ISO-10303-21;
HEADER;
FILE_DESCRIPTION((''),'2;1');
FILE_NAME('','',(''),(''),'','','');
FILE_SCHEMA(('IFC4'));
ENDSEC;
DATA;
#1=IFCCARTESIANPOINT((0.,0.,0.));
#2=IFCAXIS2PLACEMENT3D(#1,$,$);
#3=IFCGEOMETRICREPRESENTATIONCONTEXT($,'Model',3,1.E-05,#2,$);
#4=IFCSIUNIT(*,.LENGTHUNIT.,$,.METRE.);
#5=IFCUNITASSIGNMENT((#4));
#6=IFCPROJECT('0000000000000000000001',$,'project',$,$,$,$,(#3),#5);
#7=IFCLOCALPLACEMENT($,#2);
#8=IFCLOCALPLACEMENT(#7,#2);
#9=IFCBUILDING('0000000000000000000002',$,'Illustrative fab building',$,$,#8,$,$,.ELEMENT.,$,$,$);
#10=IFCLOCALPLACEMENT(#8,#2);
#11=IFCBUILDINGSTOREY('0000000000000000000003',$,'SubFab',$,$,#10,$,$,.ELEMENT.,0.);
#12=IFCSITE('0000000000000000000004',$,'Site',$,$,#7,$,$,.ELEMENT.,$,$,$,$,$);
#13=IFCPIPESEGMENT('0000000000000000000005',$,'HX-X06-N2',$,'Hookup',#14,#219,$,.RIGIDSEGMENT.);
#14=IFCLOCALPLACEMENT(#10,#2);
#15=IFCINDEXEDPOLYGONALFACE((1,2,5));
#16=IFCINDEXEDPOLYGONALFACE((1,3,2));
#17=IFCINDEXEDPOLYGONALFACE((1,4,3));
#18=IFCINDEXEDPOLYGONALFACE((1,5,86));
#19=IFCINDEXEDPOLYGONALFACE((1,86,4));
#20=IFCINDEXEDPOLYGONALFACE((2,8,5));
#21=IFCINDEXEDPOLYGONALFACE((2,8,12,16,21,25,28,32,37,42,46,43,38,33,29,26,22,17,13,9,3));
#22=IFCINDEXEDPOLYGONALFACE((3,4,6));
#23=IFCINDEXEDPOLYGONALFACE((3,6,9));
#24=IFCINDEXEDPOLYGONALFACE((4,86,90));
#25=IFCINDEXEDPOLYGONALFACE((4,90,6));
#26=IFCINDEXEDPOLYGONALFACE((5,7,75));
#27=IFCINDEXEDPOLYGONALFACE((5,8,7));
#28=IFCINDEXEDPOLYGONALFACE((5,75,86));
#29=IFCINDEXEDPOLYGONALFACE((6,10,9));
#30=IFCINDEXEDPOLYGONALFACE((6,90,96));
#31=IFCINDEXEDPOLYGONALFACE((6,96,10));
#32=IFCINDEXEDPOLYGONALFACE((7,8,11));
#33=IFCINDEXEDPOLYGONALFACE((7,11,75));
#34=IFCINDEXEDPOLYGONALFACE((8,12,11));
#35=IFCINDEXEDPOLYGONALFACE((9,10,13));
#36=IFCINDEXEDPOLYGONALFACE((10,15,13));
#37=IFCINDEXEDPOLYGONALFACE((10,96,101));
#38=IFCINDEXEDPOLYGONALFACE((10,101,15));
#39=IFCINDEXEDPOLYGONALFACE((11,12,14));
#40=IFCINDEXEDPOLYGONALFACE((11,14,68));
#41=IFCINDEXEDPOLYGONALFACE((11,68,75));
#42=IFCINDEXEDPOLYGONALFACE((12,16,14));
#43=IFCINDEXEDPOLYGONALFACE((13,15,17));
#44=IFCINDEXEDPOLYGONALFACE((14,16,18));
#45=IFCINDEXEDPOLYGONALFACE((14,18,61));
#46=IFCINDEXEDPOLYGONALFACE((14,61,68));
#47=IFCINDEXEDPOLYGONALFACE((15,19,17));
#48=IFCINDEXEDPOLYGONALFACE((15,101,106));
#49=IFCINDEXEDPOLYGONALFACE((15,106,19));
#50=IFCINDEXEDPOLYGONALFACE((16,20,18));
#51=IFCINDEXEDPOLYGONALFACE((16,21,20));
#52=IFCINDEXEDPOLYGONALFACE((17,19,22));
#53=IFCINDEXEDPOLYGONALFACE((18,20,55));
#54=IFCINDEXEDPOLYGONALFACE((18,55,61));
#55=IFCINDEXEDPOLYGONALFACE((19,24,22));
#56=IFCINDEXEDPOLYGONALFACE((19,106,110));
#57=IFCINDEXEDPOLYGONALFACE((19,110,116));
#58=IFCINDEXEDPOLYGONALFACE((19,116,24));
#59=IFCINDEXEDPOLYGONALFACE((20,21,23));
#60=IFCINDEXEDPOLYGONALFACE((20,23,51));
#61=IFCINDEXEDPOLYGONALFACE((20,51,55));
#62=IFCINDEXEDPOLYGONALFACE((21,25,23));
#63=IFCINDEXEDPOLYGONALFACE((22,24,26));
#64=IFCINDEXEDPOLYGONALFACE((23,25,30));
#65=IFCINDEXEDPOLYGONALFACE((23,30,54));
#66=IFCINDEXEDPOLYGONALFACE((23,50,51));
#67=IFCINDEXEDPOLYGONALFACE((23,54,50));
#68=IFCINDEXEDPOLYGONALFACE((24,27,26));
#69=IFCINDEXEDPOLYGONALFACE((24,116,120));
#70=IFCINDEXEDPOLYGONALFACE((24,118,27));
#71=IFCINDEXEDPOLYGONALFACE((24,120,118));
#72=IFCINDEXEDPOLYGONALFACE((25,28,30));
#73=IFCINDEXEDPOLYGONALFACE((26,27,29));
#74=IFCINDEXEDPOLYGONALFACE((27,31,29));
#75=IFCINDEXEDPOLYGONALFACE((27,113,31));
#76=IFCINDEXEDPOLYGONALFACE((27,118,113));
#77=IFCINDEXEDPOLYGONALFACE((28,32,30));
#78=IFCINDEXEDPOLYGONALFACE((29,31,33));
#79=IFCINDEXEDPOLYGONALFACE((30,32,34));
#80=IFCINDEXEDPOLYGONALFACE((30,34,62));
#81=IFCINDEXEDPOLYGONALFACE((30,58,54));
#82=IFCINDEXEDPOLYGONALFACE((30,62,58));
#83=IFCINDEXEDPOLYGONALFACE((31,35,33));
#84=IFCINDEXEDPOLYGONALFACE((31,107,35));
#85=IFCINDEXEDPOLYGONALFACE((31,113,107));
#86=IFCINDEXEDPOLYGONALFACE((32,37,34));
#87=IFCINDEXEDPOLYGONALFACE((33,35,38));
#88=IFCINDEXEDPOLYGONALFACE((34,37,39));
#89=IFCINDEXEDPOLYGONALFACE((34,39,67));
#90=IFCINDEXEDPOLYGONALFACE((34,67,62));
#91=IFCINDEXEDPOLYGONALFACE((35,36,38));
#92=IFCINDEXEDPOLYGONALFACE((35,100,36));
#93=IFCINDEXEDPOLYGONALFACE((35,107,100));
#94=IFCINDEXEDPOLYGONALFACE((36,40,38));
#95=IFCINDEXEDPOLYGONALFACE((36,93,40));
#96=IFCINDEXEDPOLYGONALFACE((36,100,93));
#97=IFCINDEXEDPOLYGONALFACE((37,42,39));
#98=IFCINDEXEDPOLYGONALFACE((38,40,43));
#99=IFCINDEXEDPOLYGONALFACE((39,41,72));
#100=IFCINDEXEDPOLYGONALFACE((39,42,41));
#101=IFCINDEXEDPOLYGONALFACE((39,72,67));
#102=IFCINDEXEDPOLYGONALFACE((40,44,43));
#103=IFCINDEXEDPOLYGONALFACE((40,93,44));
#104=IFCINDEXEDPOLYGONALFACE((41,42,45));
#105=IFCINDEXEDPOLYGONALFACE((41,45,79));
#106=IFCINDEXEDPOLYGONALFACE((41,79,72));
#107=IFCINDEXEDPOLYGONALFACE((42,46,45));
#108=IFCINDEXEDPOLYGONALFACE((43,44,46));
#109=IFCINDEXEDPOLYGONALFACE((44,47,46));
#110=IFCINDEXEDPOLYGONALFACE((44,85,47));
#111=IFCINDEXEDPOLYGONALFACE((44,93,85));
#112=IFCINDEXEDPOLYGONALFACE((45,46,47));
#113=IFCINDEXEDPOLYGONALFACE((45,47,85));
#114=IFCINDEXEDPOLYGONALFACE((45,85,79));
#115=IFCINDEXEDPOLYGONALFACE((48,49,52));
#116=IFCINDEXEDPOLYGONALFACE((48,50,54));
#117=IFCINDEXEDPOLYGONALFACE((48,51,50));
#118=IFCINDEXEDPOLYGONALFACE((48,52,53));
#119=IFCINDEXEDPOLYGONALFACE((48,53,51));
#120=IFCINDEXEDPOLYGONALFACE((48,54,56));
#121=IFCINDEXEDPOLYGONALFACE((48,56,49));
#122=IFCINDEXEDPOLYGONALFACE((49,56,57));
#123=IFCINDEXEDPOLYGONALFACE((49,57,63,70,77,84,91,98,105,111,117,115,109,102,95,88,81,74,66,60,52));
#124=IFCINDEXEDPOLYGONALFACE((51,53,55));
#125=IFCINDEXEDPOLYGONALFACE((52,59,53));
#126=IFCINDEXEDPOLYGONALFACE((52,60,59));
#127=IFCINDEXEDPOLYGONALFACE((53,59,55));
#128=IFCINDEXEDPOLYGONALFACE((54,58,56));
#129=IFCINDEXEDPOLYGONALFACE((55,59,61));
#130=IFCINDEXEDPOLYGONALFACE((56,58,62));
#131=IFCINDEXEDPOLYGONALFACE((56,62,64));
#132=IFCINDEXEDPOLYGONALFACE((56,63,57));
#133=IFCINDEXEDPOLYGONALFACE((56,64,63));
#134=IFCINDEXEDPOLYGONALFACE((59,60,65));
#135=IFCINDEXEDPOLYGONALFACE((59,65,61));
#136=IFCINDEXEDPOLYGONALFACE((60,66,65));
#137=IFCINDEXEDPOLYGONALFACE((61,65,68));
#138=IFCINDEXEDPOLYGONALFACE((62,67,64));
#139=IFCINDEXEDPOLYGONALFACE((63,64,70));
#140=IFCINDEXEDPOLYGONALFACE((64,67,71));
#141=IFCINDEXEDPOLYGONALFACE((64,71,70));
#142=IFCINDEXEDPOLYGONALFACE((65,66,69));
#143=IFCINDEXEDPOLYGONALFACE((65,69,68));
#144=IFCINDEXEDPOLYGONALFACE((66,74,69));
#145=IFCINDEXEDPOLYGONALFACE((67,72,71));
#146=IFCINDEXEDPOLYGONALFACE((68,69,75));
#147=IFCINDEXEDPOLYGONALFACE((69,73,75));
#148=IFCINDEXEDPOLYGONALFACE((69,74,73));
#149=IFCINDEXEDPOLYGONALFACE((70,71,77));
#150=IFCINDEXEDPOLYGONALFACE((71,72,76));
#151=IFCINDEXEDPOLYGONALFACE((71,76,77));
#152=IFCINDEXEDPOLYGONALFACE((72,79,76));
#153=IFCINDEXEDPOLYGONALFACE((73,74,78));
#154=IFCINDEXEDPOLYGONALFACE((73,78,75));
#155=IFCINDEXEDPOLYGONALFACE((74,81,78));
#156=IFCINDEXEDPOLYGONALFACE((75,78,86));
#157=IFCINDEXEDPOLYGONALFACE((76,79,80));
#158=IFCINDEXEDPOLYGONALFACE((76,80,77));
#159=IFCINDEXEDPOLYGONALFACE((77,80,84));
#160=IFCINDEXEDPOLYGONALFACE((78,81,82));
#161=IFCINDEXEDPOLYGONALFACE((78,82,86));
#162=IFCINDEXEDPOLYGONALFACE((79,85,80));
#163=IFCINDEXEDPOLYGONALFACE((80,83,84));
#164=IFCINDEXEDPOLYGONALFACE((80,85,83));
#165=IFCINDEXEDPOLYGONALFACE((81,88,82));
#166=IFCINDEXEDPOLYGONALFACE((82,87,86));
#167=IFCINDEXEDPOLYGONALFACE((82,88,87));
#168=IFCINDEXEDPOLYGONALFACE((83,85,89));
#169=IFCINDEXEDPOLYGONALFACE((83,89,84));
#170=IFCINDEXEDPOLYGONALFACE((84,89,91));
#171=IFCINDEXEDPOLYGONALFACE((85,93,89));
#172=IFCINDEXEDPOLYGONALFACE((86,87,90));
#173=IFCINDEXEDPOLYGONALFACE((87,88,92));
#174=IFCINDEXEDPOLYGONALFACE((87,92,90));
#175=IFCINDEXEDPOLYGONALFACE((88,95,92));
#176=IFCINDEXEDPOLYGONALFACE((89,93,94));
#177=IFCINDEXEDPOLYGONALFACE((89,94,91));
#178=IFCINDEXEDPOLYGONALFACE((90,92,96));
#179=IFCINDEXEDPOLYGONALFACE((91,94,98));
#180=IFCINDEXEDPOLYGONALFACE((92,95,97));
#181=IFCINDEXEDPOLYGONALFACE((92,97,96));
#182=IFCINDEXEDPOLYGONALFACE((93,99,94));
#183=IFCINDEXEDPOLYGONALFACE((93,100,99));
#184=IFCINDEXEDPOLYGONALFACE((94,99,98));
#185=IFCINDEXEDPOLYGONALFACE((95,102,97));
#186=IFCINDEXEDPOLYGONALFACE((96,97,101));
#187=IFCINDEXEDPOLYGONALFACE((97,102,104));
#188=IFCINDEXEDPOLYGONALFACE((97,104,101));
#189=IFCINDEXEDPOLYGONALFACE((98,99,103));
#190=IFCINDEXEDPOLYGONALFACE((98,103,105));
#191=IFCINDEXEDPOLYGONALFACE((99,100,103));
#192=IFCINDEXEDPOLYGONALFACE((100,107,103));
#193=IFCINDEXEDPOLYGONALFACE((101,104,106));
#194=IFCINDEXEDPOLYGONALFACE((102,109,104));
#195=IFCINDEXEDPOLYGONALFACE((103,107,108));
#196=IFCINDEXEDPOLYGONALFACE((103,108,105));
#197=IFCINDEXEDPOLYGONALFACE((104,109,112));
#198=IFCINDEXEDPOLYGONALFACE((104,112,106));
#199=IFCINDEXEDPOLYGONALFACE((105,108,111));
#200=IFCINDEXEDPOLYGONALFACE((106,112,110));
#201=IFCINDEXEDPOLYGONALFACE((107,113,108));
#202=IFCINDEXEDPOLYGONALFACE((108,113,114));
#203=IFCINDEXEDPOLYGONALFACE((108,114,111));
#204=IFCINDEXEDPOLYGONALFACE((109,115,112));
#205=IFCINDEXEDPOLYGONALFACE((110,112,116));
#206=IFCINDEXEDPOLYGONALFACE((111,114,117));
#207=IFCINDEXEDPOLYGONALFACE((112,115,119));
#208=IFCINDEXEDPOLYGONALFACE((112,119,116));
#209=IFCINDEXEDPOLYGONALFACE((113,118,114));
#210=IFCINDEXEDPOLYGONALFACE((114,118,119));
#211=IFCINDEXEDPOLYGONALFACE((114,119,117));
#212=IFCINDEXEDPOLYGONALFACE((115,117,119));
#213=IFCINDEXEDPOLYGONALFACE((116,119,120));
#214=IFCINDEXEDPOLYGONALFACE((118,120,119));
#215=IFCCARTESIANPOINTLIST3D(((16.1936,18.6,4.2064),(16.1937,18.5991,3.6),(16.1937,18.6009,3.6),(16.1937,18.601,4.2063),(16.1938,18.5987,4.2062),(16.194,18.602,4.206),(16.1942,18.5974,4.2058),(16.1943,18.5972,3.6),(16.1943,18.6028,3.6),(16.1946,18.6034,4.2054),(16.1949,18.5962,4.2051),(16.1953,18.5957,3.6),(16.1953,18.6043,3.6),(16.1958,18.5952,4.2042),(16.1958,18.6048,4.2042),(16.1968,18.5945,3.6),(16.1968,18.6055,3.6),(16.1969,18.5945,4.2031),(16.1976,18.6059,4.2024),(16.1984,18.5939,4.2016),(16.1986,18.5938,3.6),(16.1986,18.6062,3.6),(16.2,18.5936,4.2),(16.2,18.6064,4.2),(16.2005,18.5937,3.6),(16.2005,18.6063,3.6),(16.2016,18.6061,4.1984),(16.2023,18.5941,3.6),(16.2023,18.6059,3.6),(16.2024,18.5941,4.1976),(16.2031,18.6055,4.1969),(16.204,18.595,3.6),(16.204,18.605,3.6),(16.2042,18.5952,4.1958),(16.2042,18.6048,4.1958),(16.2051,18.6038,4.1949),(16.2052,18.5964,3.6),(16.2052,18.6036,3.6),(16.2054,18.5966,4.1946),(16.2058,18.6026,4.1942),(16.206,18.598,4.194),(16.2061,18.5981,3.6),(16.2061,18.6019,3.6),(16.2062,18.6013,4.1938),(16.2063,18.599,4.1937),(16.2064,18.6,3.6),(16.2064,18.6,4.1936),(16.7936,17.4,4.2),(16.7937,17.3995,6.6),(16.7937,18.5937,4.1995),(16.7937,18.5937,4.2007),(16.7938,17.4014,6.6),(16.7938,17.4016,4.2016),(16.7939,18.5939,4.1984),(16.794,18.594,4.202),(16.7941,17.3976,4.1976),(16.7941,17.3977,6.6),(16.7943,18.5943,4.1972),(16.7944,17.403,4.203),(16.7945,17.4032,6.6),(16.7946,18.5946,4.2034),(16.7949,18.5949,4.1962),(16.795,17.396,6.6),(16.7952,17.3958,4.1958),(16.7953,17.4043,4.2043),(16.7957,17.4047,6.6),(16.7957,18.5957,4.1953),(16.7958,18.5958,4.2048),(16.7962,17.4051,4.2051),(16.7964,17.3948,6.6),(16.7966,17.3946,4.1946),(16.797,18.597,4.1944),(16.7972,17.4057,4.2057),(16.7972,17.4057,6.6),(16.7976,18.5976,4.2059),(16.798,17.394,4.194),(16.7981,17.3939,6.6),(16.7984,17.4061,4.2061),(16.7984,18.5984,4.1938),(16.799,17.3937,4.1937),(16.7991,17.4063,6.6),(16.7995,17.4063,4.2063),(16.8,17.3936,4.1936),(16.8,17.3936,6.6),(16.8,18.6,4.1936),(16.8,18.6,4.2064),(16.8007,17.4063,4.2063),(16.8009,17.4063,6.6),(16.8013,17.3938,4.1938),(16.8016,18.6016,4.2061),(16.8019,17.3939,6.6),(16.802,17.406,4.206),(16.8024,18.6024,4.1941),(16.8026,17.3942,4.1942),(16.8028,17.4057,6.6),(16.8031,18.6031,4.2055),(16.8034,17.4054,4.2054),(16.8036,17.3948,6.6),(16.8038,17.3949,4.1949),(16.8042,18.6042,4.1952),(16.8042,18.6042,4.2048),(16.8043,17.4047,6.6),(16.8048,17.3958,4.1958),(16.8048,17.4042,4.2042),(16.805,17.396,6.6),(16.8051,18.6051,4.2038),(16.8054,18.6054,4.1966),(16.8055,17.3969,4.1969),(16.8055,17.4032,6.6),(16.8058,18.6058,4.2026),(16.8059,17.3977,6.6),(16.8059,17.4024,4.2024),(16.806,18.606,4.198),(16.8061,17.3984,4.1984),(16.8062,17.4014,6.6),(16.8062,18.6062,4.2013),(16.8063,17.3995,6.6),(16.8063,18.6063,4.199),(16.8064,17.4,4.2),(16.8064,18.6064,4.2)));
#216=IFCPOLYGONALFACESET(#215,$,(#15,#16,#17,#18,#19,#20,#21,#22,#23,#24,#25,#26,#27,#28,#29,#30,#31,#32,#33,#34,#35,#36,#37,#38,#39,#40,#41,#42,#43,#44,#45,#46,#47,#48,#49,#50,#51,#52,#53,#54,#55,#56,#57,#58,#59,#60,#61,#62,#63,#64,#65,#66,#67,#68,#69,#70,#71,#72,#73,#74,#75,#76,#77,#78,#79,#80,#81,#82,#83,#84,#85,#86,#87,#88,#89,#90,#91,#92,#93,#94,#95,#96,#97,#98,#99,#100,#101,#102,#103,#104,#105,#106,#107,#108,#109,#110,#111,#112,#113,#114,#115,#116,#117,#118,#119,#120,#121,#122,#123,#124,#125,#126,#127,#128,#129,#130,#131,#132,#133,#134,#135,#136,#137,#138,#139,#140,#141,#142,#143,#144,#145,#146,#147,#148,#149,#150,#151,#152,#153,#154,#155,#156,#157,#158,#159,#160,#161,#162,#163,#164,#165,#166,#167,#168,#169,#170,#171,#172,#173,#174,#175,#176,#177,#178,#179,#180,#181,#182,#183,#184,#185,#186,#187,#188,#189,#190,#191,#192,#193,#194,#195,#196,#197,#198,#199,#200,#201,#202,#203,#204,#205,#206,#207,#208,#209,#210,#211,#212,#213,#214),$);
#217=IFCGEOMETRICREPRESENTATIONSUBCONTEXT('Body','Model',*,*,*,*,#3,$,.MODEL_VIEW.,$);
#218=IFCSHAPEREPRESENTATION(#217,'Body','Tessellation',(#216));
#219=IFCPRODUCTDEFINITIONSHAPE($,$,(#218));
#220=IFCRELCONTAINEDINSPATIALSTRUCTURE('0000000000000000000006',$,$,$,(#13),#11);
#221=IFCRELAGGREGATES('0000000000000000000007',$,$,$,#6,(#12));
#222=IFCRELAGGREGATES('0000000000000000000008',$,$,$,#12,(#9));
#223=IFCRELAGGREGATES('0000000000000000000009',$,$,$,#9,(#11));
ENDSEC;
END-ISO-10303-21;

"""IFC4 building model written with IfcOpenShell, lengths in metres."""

from ifc_helpers import new_model, entity, si_unit, origin, place, context, subcontext, project, spatial, element, save


model = new_model("IFC4")

# Units and contexts
model_context = context("Model", 3, precision=1e-05, world=origin())
body_context = subcontext(model_context, "Body", "Model", "MODEL_VIEW")
ifc_project = project(units=[si_unit("LENGTHUNIT", "METRE")], contexts=[model_context])

# Site, building, storey
site_placement = place(None, origin())
site = spatial("IfcSite", under=ifc_project, at=site_placement, Name="Site", CompositionType="ELEMENT")
building_placement = place(site_placement, origin())
building = spatial("IfcBuilding", under=site, at=building_placement, Name="Illustrative fab building", CompositionType="ELEMENT")
storey_placement = place(building_placement, origin())
storey = spatial("IfcBuildingStorey", under=building, at=storey_placement, Name="SubFab", CompositionType="ELEMENT", Elevation=0.0)

# Pipe segment
pipe_segment_1_placement = place(storey_placement, origin())
element("IfcPipeSegment", 1, at=pipe_segment_1_placement, inside=storey, Name="HX-X06-N2", ObjectType="Hookup", PredefinedType="RIGIDSEGMENT", context=body_context, shape_type="AdvancedSweptSolid", body=[
    entity("IfcSweptDiskSolid", entity("IfcPolyline", [entity("IfcCartesianPoint", [16.2, 18.6, 3.6]), entity("IfcCartesianPoint", [16.2, 18.6, 4.2]), entity("IfcCartesianPoint", [16.8, 18.6, 4.2]), entity("IfcCartesianPoint", [16.8, 17.4, 4.2]), entity("IfcCartesianPoint", [16.8, 17.4, 6.6])]), 0.0063),
])

save(model, "model.ifc")
